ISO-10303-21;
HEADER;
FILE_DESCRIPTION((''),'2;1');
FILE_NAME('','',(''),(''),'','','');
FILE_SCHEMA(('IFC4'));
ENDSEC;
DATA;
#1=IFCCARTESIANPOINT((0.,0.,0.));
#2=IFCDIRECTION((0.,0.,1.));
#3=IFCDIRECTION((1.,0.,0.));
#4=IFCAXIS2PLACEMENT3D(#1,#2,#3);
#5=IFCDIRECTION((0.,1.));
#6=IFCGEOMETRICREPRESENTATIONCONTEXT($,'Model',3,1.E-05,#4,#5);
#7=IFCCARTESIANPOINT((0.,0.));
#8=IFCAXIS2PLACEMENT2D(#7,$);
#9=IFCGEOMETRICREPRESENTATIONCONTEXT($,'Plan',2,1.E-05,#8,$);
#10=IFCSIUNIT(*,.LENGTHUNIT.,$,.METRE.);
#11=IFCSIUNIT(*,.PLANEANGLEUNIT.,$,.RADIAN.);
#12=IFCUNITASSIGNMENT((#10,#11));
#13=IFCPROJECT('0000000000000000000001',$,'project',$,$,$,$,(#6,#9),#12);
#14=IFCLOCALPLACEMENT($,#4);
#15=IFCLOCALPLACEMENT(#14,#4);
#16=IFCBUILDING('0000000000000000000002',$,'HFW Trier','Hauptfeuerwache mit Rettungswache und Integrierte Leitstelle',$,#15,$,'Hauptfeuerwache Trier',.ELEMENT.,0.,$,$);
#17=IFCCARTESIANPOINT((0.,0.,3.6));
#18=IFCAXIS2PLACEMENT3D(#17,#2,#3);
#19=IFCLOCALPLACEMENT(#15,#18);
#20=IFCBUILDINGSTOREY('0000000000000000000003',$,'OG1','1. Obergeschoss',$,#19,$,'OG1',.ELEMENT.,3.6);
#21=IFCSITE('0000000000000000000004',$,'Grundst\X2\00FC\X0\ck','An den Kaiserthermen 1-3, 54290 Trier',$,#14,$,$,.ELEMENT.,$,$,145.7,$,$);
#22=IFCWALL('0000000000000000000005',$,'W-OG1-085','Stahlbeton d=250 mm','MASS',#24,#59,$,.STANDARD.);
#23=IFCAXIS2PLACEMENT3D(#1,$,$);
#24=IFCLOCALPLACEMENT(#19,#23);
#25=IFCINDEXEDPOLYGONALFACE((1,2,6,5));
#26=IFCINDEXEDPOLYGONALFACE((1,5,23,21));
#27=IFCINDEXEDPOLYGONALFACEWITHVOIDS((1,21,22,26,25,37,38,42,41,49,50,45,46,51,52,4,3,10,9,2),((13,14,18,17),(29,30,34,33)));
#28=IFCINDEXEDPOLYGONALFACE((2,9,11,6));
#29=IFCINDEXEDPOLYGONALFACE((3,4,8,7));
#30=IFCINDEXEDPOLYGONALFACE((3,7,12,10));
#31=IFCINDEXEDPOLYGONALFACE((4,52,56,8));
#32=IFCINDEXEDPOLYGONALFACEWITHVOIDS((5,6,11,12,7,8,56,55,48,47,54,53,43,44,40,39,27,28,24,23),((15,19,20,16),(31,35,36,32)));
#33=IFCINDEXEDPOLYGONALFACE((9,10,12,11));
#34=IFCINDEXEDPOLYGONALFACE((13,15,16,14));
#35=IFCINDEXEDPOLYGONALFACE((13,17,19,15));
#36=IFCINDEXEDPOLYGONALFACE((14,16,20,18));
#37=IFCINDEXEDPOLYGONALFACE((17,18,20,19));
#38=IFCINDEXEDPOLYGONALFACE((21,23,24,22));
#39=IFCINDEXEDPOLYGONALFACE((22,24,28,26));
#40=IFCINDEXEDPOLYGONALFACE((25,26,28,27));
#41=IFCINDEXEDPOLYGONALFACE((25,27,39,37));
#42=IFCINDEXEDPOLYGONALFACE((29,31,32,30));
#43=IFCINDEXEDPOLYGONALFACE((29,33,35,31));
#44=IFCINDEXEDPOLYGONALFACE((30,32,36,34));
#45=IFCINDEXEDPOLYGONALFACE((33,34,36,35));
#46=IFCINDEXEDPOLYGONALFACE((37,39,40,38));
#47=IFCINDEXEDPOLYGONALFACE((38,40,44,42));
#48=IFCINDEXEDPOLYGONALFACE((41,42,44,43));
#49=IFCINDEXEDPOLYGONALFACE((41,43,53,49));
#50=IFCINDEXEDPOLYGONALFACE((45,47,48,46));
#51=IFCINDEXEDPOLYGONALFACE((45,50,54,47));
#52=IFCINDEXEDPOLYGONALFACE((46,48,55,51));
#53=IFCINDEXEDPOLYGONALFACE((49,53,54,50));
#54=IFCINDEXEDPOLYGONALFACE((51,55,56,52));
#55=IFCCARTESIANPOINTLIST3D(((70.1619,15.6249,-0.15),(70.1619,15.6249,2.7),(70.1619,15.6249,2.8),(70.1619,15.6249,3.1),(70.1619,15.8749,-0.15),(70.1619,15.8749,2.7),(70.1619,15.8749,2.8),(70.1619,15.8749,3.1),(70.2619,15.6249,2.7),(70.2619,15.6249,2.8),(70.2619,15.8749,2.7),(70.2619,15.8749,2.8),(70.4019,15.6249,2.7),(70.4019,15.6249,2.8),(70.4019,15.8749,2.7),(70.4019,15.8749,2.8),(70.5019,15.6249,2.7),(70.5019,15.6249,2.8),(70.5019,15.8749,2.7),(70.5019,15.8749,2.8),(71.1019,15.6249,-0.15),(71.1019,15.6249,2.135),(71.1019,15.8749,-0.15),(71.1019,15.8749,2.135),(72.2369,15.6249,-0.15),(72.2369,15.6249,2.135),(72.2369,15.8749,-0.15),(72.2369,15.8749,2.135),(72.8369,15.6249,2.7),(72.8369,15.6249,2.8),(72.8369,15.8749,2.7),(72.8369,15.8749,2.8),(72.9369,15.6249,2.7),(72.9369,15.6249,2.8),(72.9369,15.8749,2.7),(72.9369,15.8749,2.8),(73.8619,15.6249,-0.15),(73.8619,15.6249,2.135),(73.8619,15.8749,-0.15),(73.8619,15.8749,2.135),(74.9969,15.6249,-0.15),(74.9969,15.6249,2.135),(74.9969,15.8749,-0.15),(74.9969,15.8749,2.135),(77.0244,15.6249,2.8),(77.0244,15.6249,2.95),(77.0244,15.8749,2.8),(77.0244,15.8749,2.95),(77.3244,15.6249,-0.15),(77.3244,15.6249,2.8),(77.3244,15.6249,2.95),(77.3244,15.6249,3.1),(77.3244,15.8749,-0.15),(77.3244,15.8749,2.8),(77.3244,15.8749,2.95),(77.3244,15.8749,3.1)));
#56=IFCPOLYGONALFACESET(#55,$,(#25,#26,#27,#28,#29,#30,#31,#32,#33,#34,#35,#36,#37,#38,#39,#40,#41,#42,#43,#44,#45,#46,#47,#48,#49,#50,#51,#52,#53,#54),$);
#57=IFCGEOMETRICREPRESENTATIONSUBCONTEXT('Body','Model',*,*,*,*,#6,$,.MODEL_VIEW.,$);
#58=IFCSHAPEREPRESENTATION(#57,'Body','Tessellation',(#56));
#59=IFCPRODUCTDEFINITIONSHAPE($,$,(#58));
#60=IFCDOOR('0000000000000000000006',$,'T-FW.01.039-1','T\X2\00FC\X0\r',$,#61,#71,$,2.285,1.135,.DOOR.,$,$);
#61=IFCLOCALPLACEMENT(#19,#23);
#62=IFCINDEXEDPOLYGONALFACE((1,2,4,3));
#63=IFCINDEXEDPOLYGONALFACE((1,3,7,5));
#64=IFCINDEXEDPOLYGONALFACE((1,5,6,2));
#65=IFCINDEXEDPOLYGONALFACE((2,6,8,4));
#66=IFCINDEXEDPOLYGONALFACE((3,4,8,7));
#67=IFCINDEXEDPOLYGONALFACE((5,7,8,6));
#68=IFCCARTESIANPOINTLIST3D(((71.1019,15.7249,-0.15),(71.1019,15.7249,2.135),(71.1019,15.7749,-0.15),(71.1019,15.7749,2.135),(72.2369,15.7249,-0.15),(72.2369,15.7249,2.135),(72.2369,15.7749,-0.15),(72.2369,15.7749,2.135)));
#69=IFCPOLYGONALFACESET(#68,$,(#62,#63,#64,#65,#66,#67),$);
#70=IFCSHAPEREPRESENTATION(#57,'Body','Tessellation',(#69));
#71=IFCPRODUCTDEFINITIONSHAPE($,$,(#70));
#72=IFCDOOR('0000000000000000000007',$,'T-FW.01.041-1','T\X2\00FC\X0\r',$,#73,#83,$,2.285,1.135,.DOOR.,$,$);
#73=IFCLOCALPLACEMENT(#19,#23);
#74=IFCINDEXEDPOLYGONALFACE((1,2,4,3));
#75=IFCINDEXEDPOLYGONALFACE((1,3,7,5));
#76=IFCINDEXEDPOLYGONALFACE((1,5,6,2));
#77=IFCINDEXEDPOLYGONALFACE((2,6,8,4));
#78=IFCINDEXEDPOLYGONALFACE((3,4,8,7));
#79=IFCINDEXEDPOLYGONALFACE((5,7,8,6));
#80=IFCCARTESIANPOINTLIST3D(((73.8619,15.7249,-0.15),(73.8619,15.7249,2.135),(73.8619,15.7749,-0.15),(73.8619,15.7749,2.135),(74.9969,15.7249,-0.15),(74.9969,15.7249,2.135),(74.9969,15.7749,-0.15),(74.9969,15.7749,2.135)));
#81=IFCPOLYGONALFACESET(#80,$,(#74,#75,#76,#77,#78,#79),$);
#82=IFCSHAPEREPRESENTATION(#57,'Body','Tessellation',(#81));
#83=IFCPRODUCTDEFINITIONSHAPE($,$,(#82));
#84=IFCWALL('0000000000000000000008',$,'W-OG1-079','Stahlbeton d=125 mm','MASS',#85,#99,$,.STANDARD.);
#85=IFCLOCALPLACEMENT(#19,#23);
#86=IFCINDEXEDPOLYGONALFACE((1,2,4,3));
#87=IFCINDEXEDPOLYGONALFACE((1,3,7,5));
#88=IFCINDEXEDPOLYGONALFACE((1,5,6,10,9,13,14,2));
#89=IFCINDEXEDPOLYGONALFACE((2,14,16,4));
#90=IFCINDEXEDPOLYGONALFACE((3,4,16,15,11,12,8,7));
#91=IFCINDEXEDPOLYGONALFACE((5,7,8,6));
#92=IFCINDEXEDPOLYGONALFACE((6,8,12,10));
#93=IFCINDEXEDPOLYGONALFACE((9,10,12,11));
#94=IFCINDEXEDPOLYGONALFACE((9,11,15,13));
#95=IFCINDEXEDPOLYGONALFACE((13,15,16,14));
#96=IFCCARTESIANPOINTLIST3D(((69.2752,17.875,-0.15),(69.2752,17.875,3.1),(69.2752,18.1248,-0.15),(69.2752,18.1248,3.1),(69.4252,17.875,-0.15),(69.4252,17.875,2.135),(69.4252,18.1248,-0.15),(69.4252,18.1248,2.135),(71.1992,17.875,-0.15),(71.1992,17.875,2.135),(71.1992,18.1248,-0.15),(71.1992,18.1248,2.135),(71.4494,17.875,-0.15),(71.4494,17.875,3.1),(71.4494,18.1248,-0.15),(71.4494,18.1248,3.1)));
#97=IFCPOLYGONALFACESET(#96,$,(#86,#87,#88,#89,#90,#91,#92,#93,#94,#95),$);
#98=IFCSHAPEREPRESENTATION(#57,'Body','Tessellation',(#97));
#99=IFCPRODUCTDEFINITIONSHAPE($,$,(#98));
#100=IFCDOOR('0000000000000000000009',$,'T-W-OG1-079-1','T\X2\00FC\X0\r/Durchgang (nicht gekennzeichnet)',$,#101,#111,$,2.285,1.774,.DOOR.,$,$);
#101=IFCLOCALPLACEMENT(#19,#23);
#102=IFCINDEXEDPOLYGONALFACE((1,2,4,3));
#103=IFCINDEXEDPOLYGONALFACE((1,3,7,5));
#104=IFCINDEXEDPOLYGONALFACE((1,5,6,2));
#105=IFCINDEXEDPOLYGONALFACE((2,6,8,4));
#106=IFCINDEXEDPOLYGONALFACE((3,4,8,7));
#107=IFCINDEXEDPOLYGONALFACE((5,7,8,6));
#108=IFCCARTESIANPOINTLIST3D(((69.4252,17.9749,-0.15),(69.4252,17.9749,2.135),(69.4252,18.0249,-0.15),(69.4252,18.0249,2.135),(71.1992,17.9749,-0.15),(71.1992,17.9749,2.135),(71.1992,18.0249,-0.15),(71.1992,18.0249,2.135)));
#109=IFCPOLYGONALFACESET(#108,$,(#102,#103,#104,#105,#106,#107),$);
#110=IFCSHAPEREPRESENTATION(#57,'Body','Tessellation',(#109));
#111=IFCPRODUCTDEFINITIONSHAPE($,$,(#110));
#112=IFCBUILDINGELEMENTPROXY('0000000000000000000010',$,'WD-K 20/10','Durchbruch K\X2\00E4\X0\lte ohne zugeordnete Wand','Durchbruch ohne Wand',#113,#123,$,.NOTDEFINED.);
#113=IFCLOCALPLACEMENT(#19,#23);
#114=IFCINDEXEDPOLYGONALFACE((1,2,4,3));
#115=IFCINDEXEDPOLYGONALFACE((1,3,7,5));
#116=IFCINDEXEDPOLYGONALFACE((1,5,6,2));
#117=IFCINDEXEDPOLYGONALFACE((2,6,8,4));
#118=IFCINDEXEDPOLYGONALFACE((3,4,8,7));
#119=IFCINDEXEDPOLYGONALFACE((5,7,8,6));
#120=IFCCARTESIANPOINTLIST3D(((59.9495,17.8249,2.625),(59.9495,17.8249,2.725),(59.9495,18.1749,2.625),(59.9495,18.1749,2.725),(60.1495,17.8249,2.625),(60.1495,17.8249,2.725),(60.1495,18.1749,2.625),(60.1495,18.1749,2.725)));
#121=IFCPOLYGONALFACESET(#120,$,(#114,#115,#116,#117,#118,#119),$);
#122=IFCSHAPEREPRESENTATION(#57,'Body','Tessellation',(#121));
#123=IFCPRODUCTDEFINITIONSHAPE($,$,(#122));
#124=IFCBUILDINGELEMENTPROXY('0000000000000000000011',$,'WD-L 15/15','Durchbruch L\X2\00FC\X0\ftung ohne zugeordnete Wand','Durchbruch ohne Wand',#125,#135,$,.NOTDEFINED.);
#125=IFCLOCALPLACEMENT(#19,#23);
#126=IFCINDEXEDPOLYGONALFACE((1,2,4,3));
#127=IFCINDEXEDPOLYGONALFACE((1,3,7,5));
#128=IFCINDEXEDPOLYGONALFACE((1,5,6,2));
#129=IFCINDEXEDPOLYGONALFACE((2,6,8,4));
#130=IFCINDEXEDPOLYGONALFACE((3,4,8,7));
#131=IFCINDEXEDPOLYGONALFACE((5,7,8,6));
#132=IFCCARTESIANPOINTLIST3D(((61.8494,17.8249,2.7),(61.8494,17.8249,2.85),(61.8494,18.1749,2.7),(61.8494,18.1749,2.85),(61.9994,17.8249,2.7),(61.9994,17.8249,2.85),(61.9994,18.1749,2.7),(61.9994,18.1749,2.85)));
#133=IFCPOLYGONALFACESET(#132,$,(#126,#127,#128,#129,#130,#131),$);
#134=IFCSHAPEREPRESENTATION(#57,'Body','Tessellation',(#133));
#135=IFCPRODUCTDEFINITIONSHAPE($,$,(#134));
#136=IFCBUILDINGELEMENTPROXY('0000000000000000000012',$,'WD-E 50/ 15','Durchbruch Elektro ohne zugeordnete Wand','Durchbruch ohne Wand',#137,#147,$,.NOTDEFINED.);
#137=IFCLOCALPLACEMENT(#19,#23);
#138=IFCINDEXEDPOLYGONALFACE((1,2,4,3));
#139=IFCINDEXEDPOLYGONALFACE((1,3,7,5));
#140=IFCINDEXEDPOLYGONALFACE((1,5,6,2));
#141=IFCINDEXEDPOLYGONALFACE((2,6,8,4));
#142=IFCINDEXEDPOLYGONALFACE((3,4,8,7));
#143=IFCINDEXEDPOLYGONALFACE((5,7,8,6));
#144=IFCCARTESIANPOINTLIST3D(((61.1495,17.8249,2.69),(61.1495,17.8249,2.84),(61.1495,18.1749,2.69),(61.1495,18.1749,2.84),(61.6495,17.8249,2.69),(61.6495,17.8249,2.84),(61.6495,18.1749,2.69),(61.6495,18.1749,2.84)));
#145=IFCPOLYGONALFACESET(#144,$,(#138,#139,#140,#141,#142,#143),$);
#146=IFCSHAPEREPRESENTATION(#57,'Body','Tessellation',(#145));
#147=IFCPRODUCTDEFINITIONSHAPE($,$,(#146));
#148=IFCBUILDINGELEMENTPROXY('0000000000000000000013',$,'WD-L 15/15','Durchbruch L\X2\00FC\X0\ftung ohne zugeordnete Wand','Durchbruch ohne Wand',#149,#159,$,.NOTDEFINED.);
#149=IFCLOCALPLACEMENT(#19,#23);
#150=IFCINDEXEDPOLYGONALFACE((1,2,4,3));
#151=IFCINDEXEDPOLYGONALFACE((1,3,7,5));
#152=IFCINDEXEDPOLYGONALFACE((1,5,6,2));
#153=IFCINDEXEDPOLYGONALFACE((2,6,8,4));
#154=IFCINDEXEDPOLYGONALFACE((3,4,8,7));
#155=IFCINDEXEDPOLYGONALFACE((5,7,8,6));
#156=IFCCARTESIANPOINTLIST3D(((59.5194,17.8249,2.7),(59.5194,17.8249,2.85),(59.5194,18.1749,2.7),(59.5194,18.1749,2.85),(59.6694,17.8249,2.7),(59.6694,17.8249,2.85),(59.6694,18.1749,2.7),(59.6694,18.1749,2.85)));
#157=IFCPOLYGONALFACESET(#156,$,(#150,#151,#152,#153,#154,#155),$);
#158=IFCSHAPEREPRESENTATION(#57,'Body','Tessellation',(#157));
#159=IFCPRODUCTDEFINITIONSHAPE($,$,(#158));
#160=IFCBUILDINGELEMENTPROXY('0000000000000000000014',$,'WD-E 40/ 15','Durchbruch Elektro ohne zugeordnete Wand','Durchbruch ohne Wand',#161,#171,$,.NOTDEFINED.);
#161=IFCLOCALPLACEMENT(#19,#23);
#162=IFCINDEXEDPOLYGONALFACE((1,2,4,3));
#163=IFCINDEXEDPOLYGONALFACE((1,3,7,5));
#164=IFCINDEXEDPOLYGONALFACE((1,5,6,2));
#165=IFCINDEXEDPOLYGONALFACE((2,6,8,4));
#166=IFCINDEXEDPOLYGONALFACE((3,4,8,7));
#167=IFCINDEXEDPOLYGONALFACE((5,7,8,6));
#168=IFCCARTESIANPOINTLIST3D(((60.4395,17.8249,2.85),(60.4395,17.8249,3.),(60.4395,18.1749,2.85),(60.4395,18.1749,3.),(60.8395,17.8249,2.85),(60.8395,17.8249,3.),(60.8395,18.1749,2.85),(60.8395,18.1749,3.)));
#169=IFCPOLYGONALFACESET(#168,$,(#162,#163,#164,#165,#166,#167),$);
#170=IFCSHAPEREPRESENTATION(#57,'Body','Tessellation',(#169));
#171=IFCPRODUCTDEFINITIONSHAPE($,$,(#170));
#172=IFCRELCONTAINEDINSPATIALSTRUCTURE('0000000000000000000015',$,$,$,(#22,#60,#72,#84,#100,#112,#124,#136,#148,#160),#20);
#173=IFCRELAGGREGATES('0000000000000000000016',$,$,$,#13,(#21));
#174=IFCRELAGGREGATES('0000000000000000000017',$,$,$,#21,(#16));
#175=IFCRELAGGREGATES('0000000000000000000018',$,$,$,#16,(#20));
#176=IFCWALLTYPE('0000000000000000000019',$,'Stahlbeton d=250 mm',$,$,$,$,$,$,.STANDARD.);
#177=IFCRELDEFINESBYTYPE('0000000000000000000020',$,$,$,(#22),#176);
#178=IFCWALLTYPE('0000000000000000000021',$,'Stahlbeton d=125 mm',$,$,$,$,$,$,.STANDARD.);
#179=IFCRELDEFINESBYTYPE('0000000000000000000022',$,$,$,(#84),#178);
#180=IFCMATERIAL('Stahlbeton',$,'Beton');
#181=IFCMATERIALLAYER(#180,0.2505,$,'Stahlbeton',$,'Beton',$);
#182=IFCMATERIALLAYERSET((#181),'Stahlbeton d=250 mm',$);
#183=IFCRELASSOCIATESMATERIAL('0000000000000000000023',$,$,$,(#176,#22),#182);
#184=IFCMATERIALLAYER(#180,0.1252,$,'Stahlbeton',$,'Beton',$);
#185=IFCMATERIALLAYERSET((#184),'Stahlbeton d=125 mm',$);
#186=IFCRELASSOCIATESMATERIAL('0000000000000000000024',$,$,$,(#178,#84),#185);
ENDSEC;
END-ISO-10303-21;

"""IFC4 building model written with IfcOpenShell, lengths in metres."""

from ifc_helpers import new_model, si_unit, direction, frame, frame_2d, origin_with_axes, origin_2d, place, context, subcontext, project, spatial, rectangle, extrude, material, layer, layer_set, layer_usage, type_object, element, fill, save


model = new_model("IFC4")

# Units and contexts
model_context = context("Model", 3, precision=1e-05, world=origin_with_axes(), true_north=direction((0.0, 1.0)))
plan_context = context("Plan", 2, precision=1e-05, world=origin_2d())
body_context = subcontext(model_context, "Body", "Model", "MODEL_VIEW")
ifc_project = project(units=[si_unit("LENGTHUNIT", "METRE"), si_unit("PLANEANGLEUNIT", "RADIAN")], contexts=[model_context, plan_context])

# Site, building, storey
site_placement = place(None, origin_with_axes())
site = spatial("IfcSite", under=ifc_project, at=site_placement, Name="Grundstück", Description="An den Kaiserthermen 1-3, 54290 Trier", CompositionType="ELEMENT", RefElevation=145.7)
building_placement = place(site_placement, origin_with_axes())
building = spatial("IfcBuilding", under=site, at=building_placement, Name="HFW Trier", Description="Hauptfeuerwache mit Rettungswache und Integrierte Leitstelle", LongName="Hauptfeuerwache Trier", CompositionType="ELEMENT", ElevationOfRefHeight=0.0)
storey_placement = place(building_placement, frame((0.0, 0.0, 3.6), z_axis=(0.0, 0.0, 1.0), x_axis=(1.0, 0.0, 0.0)))
storey = spatial("IfcBuildingStorey", under=building, at=storey_placement, Name="OG1", Description="1. Obergeschoss", LongName="OG1", CompositionType="ELEMENT", Elevation=3.6)

# Wall, openings, doors
ifc_material = material(Name="Stahlbeton", Category="Beton")
ifc_layer_1 = layer(ifc_material, 0.2505, Name="Stahlbeton", Category="Beton")
ifc_layer_set_1 = layer_set([ifc_layer_1], Name="Stahlbeton d=250 mm")
wall_type_1 = type_object("IfcWallType", Name="Stahlbeton d=250 mm", PredefinedType="STANDARD", material=ifc_layer_set_1)
ifc_layer_usage_1 = layer_usage(ifc_layer_set_1, "AXIS2", "POSITIVE", -0.125)
wall_1_placement = place(storey_placement, frame((70.1619, 15.7499, -0.15), z_axis=(0.0, 0.0, 1.0), x_axis=(1.0, 0.0, 0.0)))
wall_1 = element("IfcWall", 1, at=wall_1_placement, inside=storey, type_object=wall_type_1, material=ifc_layer_usage_1, Name="W-OG1-085", Description="Stahlbeton d=250 mm", ObjectType="MASS", PredefinedType="STANDARD", context=body_context, shape_type="SweptSolid", body=[
    extrude(rectangle(XDim=7.1625, YDim=0.25, at=frame_2d((3.5812, 0.0))), origin_with_axes(), (0.0, 0.0, 1.0), 3.25),
])
opening_1_placement = place(wall_1_placement, frame((0.94, 0.0, 0.0), z_axis=(0.0, 0.0, 1.0), x_axis=(1.0, 0.0, 0.0)))
opening_1 = element("IfcOpeningElement", 2, at=opening_1_placement, cuts=wall_1, PredefinedType="OPENING", context=body_context, shape_type="SweptSolid", body=[
    extrude(rectangle(XDim=1.135, YDim=0.35, at=frame_2d((0.5675, 0.0))), origin_with_axes(), (0.0, 0.0, 1.0), 2.285),
])
opening_2_placement = place(wall_1_placement, frame((3.7, 0.0, 0.0), z_axis=(0.0, 0.0, 1.0), x_axis=(1.0, 0.0, 0.0)))
opening_2 = element("IfcOpeningElement", 3, at=opening_2_placement, cuts=wall_1, PredefinedType="OPENING", context=body_context, shape_type="SweptSolid", body=[
    extrude(rectangle(XDim=1.135, YDim=0.35, at=frame_2d((0.5675, 0.0))), origin_with_axes(), (0.0, 0.0, 1.0), 2.285),
])
opening_3_placement = place(wall_1_placement, origin_with_axes())
element("IfcOpeningElement", 4, at=opening_3_placement, cuts=wall_1, ObjectType="Wanddurchbruch", PredefinedType="OPENING", context=body_context, shape_type="SweptSolid", body=[
    extrude(rectangle(XDim=0.3, YDim=0.35, at=frame_2d((7.0125, 0.0))), frame((0.0, 0.0, 2.95), z_axis=(0.0, 0.0, 1.0), x_axis=(1.0, 0.0, 0.0)), (0.0, 0.0, 1.0), 0.15),
])
opening_4_placement = place(wall_1_placement, origin_with_axes())
element("IfcOpeningElement", 5, at=opening_4_placement, cuts=wall_1, ObjectType="Wanddurchbruch", PredefinedType="OPENING", context=body_context, shape_type="SweptSolid", body=[
    extrude(rectangle(XDim=0.1, YDim=0.35, at=frame_2d((0.05, 0.0))), frame((0.0, 0.0, 2.85), z_axis=(0.0, 0.0, 1.0), x_axis=(1.0, 0.0, 0.0)), (0.0, 0.0, 1.0), 0.1),
])
opening_5_placement = place(wall_1_placement, origin_with_axes())
element("IfcOpeningElement", 6, at=opening_5_placement, cuts=wall_1, ObjectType="Wanddurchbruch", PredefinedType="OPENING", context=body_context, shape_type="SweptSolid", body=[
    extrude(rectangle(XDim=0.1, YDim=0.35, at=frame_2d((2.725, 0.0))), frame((0.0, 0.0, 2.85), z_axis=(0.0, 0.0, 1.0), x_axis=(1.0, 0.0, 0.0)), (0.0, 0.0, 1.0), 0.1),
])
opening_6_placement = place(wall_1_placement, origin_with_axes())
element("IfcOpeningElement", 7, at=opening_6_placement, cuts=wall_1, ObjectType="Wanddurchbruch", PredefinedType="OPENING", context=body_context, shape_type="SweptSolid", body=[
    extrude(rectangle(XDim=0.1, YDim=0.35, at=frame_2d((0.29, 0.0))), frame((0.0, 0.0, 2.85), z_axis=(0.0, 0.0, 1.0), x_axis=(1.0, 0.0, 0.0)), (0.0, 0.0, 1.0), 0.1),
])
door_1_placement = place(wall_1_placement, frame((0.94, 0.0, 0.0), z_axis=(0.0, 0.0, 1.0), x_axis=(1.0, 0.0, 0.0)))
door_1 = element("IfcDoor", 8, at=door_1_placement, inside=storey, Name="T-FW.01.039-1", Description="Tür", OverallHeight=2.285, OverallWidth=1.135, PredefinedType="DOOR", context=body_context, shape_type="SweptSolid", body=[
    extrude(rectangle(XDim=1.135, YDim=0.05, at=frame_2d((0.5675, 0.0))), origin_with_axes(), (0.0, 0.0, 1.0), 2.285),
])
fill(opening_1, door_1)
door_2_placement = place(wall_1_placement, frame((3.7, 0.0, 0.0), z_axis=(0.0, 0.0, 1.0), x_axis=(1.0, 0.0, 0.0)))
door_2 = element("IfcDoor", 9, at=door_2_placement, inside=storey, Name="T-FW.01.041-1", Description="Tür", OverallHeight=2.285, OverallWidth=1.135, PredefinedType="DOOR", context=body_context, shape_type="SweptSolid", body=[
    extrude(rectangle(XDim=1.135, YDim=0.05, at=frame_2d((0.5675, 0.0))), origin_with_axes(), (0.0, 0.0, 1.0), 2.285),
])
fill(opening_2, door_2)

# Wall, opening, door
ifc_layer_2 = layer(ifc_material, 0.1252, Name="Stahlbeton", Category="Beton")
ifc_layer_set_2 = layer_set([ifc_layer_2], Name="Stahlbeton d=125 mm")
ifc_layer_usage_2 = layer_usage(ifc_layer_set_2, "AXIS2", "POSITIVE", -0.125)
wall_type_2 = type_object("IfcWallType", Name="Stahlbeton d=125 mm", PredefinedType="STANDARD", material=ifc_layer_set_2)
wall_2_placement = place(storey_placement, frame((69.2752, 17.9999, -0.15), z_axis=(0.0, 0.0, 1.0), x_axis=(1.0, 0.0, 0.0)))
wall_2 = element("IfcWall", 10, at=wall_2_placement, inside=storey, type_object=wall_type_2, material=ifc_layer_usage_2, Name="W-OG1-079", Description="Stahlbeton d=125 mm", ObjectType="MASS", PredefinedType="STANDARD", context=body_context, shape_type="SweptSolid", body=[
    extrude(rectangle(XDim=2.1742, YDim=0.2499, at=frame_2d((1.0871, 0.0))), origin_with_axes(), (0.0, 0.0, 1.0), 3.25),
])
opening_7_placement = place(wall_2_placement, frame((0.15, 0.0, 0.0), z_axis=(0.0, 0.0, 1.0), x_axis=(1.0, 0.0, 0.0)))
opening_7 = element("IfcOpeningElement", 11, at=opening_7_placement, cuts=wall_2, PredefinedType="OPENING", context=body_context, shape_type="SweptSolid", body=[
    extrude(rectangle(XDim=1.774, YDim=0.3499, at=frame_2d((0.887, 0.0))), origin_with_axes(), (0.0, 0.0, 1.0), 2.285),
])
door_3_placement = place(wall_2_placement, frame((0.15, 0.0, 0.0), z_axis=(0.0, 0.0, 1.0), x_axis=(1.0, 0.0, 0.0)))
door_3 = element("IfcDoor", 12, at=door_3_placement, inside=storey, Name="T-W-OG1-079-1", Description="Tür/Durchgang (nicht gekennzeichnet)", OverallHeight=2.285, OverallWidth=1.774, PredefinedType="DOOR", context=body_context, shape_type="SweptSolid", body=[
    extrude(rectangle(XDim=1.774, YDim=0.05, at=frame_2d((0.887, 0.0))), origin_with_axes(), (0.0, 0.0, 1.0), 2.285),
])
fill(opening_7, door_3)

# Building element proxies
proxy_1_placement = place(storey_placement, frame((60.0495, 17.9999, 2.625), z_axis=(0.0, 0.0, 1.0), x_axis=(1.0, 0.0, 0.0)))
element("IfcBuildingElementProxy", 13, at=proxy_1_placement, inside=storey, Name="WD-K 20/10", Description="Durchbruch Kälte ohne zugeordnete Wand", ObjectType="Durchbruch ohne Wand", PredefinedType="NOTDEFINED", context=body_context, shape_type="SweptSolid", body=[
    extrude(rectangle(XDim=0.2, YDim=0.35, at=origin_2d()), origin_with_axes(), (0.0, 0.0, 1.0), 0.1),
])
proxy_2_placement = place(storey_placement, frame((61.9244, 17.9999, 2.7), z_axis=(0.0, 0.0, 1.0), x_axis=(1.0, 0.0, 0.0)))
element("IfcBuildingElementProxy", 14, at=proxy_2_placement, inside=storey, Name="WD-L 15/15", Description="Durchbruch Lüftung ohne zugeordnete Wand", ObjectType="Durchbruch ohne Wand", PredefinedType="NOTDEFINED", context=body_context, shape_type="SweptSolid", body=[
    extrude(rectangle(XDim=0.15, YDim=0.35, at=origin_2d()), origin_with_axes(), (0.0, 0.0, 1.0), 0.15),
])
proxy_3_placement = place(storey_placement, frame((61.3995, 17.9999, 2.69), z_axis=(0.0, 0.0, 1.0), x_axis=(1.0, 0.0, 0.0)))
element("IfcBuildingElementProxy", 15, at=proxy_3_placement, inside=storey, Name="WD-E 50/ 15", Description="Durchbruch Elektro ohne zugeordnete Wand", ObjectType="Durchbruch ohne Wand", PredefinedType="NOTDEFINED", context=body_context, shape_type="SweptSolid", body=[
    extrude(rectangle(XDim=0.5, YDim=0.35, at=origin_2d()), origin_with_axes(), (0.0, 0.0, 1.0), 0.15),
])
proxy_4_placement = place(storey_placement, frame((59.5944, 17.9999, 2.7), z_axis=(0.0, 0.0, 1.0), x_axis=(1.0, 0.0, 0.0)))
element("IfcBuildingElementProxy", 16, at=proxy_4_placement, inside=storey, Name="WD-L 15/15", Description="Durchbruch Lüftung ohne zugeordnete Wand", ObjectType="Durchbruch ohne Wand", PredefinedType="NOTDEFINED", context=body_context, shape_type="SweptSolid", body=[
    extrude(rectangle(XDim=0.15, YDim=0.35, at=origin_2d()), origin_with_axes(), (0.0, 0.0, 1.0), 0.15),
])
proxy_5_placement = place(storey_placement, frame((60.6395, 17.9999, 2.85), z_axis=(0.0, 0.0, 1.0), x_axis=(1.0, 0.0, 0.0)))
element("IfcBuildingElementProxy", 17, at=proxy_5_placement, inside=storey, Name="WD-E 40/ 15", Description="Durchbruch Elektro ohne zugeordnete Wand", ObjectType="Durchbruch ohne Wand", PredefinedType="NOTDEFINED", context=body_context, shape_type="SweptSolid", body=[
    extrude(rectangle(XDim=0.4, YDim=0.35, at=origin_2d()), origin_with_axes(), (0.0, 0.0, 1.0), 0.15),
])

save(model, "model.ifc")
